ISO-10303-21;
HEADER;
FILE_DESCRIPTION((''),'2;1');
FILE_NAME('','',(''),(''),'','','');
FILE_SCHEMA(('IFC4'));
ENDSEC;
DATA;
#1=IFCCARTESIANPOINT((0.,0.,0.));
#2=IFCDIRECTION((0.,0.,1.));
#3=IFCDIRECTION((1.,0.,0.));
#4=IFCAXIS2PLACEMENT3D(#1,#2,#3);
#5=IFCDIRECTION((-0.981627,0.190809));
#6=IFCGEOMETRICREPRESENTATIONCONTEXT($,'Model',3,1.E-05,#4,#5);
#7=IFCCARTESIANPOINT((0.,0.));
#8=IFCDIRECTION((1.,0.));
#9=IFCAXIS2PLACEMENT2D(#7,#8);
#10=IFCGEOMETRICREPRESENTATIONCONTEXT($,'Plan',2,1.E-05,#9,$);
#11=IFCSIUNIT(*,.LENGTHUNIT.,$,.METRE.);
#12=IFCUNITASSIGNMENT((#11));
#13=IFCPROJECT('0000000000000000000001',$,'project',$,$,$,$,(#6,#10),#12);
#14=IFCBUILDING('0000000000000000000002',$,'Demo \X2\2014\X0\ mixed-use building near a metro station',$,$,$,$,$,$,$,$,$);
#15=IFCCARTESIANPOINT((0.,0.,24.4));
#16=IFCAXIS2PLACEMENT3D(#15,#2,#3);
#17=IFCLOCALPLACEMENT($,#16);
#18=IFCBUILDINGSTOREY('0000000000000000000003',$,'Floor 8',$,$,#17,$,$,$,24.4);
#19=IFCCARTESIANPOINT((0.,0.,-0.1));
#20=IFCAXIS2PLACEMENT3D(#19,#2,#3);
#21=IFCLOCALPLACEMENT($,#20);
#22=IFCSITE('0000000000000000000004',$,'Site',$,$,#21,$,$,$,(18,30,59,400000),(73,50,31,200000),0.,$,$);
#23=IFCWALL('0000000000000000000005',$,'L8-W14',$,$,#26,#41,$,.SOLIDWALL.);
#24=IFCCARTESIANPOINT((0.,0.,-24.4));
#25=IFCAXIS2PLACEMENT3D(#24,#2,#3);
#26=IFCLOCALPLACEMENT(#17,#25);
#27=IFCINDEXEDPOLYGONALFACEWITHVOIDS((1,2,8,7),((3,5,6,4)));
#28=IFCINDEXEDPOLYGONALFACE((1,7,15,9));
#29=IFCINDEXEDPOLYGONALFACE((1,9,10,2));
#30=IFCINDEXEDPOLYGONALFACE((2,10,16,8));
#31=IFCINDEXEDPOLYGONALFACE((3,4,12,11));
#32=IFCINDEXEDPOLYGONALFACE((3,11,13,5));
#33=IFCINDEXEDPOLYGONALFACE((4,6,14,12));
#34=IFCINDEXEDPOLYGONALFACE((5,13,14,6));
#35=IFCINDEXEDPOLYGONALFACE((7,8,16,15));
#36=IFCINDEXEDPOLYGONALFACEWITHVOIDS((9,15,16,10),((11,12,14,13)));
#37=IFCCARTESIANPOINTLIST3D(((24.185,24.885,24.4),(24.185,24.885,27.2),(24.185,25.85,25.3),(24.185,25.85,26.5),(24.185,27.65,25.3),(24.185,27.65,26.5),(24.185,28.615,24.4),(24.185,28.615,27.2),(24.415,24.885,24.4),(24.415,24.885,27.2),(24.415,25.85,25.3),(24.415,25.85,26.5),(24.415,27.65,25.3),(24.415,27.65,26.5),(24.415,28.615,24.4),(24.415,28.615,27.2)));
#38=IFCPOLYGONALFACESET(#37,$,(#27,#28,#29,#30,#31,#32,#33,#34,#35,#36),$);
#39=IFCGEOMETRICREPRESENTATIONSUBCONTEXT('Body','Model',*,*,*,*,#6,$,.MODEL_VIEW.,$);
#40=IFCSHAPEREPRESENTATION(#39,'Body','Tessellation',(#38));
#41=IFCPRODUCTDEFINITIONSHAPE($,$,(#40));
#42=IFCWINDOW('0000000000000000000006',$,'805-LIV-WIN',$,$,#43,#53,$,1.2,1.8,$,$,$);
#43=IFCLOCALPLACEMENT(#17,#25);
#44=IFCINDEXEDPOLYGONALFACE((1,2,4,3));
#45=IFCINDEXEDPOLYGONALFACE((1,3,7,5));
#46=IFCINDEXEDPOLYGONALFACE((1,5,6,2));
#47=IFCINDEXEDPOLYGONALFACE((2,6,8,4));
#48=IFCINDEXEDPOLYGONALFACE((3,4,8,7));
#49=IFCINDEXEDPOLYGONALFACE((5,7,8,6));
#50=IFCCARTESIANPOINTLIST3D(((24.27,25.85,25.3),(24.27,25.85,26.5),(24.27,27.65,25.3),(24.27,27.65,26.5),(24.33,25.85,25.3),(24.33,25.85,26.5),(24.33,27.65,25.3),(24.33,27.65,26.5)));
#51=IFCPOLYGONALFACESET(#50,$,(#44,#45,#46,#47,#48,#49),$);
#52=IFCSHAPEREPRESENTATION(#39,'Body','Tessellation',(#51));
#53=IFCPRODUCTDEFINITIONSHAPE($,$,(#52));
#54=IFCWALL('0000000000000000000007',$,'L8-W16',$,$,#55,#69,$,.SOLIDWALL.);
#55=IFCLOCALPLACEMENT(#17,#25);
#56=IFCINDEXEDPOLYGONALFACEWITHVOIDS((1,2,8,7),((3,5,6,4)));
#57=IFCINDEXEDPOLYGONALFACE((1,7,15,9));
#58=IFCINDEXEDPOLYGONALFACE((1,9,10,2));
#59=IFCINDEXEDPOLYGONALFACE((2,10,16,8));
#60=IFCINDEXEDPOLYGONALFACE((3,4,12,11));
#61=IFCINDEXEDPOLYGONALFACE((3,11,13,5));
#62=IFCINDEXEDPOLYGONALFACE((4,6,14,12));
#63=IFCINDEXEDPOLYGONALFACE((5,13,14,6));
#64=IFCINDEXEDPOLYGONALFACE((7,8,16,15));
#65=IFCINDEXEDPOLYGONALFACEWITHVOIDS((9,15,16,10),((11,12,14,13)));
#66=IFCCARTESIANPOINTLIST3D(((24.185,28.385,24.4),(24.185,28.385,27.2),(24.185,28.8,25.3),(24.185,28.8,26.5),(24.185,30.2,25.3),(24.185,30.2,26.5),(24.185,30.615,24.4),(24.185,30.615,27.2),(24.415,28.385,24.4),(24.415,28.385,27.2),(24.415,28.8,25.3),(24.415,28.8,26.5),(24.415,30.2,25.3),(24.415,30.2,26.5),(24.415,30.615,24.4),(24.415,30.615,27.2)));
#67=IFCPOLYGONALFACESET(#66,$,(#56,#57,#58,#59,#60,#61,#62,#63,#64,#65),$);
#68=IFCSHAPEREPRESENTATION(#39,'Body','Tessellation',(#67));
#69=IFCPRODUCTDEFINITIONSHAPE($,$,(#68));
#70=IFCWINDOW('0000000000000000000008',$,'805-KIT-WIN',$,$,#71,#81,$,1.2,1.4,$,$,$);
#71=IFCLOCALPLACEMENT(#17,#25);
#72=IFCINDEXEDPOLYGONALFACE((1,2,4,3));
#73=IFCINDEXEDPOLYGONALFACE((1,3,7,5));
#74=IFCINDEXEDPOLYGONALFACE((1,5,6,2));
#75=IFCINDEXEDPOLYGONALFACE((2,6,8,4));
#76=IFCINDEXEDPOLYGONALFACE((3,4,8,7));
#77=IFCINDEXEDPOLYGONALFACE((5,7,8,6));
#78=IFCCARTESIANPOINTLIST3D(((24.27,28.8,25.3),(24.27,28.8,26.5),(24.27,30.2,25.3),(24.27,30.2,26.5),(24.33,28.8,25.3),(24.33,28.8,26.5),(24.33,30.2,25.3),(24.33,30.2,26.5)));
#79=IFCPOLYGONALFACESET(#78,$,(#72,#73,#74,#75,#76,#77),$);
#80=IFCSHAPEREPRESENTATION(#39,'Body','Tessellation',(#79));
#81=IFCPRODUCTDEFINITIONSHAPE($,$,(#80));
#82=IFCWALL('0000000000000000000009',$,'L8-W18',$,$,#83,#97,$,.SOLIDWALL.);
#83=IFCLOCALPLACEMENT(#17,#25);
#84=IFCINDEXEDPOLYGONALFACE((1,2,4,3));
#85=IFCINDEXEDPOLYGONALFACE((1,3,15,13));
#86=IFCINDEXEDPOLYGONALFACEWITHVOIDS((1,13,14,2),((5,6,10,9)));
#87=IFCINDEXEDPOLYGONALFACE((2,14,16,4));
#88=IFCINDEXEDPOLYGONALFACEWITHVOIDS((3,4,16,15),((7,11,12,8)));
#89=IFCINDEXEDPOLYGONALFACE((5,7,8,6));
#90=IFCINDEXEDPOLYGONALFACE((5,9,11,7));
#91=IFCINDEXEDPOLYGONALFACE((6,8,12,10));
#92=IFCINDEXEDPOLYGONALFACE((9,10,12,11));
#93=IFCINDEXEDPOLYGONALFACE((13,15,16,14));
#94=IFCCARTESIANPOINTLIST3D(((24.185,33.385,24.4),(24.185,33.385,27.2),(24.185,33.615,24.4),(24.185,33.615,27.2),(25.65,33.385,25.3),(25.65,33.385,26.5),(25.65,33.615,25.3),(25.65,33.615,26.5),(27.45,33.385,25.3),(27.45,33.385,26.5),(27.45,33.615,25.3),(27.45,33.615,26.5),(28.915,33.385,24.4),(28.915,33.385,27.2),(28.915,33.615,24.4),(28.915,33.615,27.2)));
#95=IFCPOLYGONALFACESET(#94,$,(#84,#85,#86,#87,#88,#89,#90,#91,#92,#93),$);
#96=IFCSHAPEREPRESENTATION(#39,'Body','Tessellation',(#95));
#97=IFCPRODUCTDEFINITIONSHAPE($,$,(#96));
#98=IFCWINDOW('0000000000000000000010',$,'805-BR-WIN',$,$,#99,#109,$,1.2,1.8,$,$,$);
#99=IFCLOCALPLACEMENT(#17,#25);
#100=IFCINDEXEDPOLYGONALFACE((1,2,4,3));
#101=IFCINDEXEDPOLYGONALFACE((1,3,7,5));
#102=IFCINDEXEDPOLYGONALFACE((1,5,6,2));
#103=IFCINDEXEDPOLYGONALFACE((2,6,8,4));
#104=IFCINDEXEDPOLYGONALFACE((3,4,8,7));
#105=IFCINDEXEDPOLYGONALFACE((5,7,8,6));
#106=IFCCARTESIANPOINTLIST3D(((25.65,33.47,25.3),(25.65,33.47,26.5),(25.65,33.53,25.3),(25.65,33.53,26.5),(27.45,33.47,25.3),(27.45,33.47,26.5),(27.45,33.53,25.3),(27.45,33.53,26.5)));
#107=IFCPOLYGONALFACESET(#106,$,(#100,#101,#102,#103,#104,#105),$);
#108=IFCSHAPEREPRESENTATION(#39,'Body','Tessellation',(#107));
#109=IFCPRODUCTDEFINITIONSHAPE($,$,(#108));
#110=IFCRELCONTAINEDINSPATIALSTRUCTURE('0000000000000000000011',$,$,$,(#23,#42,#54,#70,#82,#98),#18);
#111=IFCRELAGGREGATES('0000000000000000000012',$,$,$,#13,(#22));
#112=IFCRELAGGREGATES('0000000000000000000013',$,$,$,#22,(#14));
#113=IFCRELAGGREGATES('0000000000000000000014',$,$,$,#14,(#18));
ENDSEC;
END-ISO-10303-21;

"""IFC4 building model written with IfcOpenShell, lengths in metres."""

from ifc_helpers import new_model, si_unit, direction, frame, origin_with_axes, origin_2d_with_axis, place, context, subcontext, project, spatial, line, indexed_curve, outline, extrude, element, fill, save


model = new_model("IFC4")

# Units and contexts
model_context = context("Model", 3, precision=1e-05, world=origin_with_axes(), true_north=direction((-0.981627, 0.190809)))
plan_context = context("Plan", 2, precision=1e-05, world=origin_2d_with_axis())
body_context = subcontext(model_context, "Body", "Model", "MODEL_VIEW")
ifc_project = project(units=[si_unit("LENGTHUNIT", "METRE")], contexts=[model_context, plan_context])

# Site, building, storey
site_placement = place(None, frame((0.0, 0.0, -0.1), z_axis=(0.0, 0.0, 1.0), x_axis=(1.0, 0.0, 0.0)))
site = spatial("IfcSite", under=ifc_project, at=site_placement, Name="Site", RefLatitude=(18, 30, 59, 400000), RefLongitude=(73, 50, 31, 200000), RefElevation=0.0)
building = spatial("IfcBuilding", under=site, Name="Demo — mixed-use building near a metro station")
storey_placement = place(None, frame((0.0, 0.0, 24.4), z_axis=(0.0, 0.0, 1.0), x_axis=(1.0, 0.0, 0.0)))
storey = spatial("IfcBuildingStorey", under=building, at=storey_placement, Name="Floor 8", Elevation=24.4)

# Wall, opening, window
wall_1_placement = place(storey_placement, frame((0.0, 0.0, -24.4), z_axis=(0.0, 0.0, 1.0), x_axis=(1.0, 0.0, 0.0)))
wall_1 = element("IfcWall", 1, at=wall_1_placement, inside=storey, Name="L8-W14", PredefinedType="SOLIDWALL", context=body_context, shape_type="SweptSolid", body=[
    extrude(outline(indexed_curve([(24.415, 28.615), (24.415, 24.885), (24.185, 24.885), (24.185, 28.615)], segments=[line(1, 2, 3, 4, 1)])), frame((0.0, 0.0, 24.4), z_axis=(0.0, 0.0, 1.0), x_axis=(1.0, 0.0, 0.0)), (0.0, 0.0, 1.0), 2.8),
])
opening_1_placement = place(wall_1_placement, origin_with_axes())
opening_1 = element("IfcOpeningElement", 2, at=opening_1_placement, cuts=wall_1, context=body_context, shape_type="SweptSolid", body=[
    extrude(outline(indexed_curve([(24.465, 27.65), (24.465, 25.85), (24.135, 25.85), (24.135, 27.65)], segments=[line(1, 2, 3, 4, 1)])), frame((0.0, 0.0, 25.3), z_axis=(0.0, 0.0, 1.0), x_axis=(1.0, 0.0, 0.0)), (0.0, 0.0, 1.0), 1.2),
])
window_1_placement = place(storey_placement, frame((0.0, 0.0, -24.4), z_axis=(0.0, 0.0, 1.0), x_axis=(1.0, 0.0, 0.0)))
window_1 = element("IfcWindow", 3, at=window_1_placement, inside=storey, Name="805-LIV-WIN", OverallHeight=1.2, OverallWidth=1.8, context=body_context, shape_type="SweptSolid", body=[
    extrude(outline(indexed_curve([(24.33, 27.65), (24.33, 25.85), (24.27, 25.85), (24.27, 27.65)], segments=[line(1, 2, 3, 4, 1)])), frame((0.0, 0.0, 25.3), z_axis=(0.0, 0.0, 1.0), x_axis=(1.0, 0.0, 0.0)), (0.0, 0.0, 1.0), 1.2),
])
fill(opening_1, window_1)

# Wall, opening, window
wall_2_placement = place(storey_placement, frame((0.0, 0.0, -24.4), z_axis=(0.0, 0.0, 1.0), x_axis=(1.0, 0.0, 0.0)))
wall_2 = element("IfcWall", 4, at=wall_2_placement, inside=storey, Name="L8-W16", PredefinedType="SOLIDWALL", context=body_context, shape_type="SweptSolid", body=[
    extrude(outline(indexed_curve([(24.415, 30.615), (24.415, 28.385), (24.185, 28.385), (24.185, 30.615)], segments=[line(1, 2, 3, 4, 1)])), frame((0.0, 0.0, 24.4), z_axis=(0.0, 0.0, 1.0), x_axis=(1.0, 0.0, 0.0)), (0.0, 0.0, 1.0), 2.8),
])
opening_2_placement = place(wall_2_placement, origin_with_axes())
opening_2 = element("IfcOpeningElement", 5, at=opening_2_placement, cuts=wall_2, context=body_context, shape_type="SweptSolid", body=[
    extrude(outline(indexed_curve([(24.465, 30.2), (24.465, 28.8), (24.135, 28.8), (24.135, 30.2)], segments=[line(1, 2, 3, 4, 1)])), frame((0.0, 0.0, 25.3), z_axis=(0.0, 0.0, 1.0), x_axis=(1.0, 0.0, 0.0)), (0.0, 0.0, 1.0), 1.2),
])
window_2_placement = place(storey_placement, frame((0.0, 0.0, -24.4), z_axis=(0.0, 0.0, 1.0), x_axis=(1.0, 0.0, 0.0)))
window_2 = element("IfcWindow", 6, at=window_2_placement, inside=storey, Name="805-KIT-WIN", OverallHeight=1.2, OverallWidth=1.4, context=body_context, shape_type="SweptSolid", body=[
    extrude(outline(indexed_curve([(24.33, 30.2), (24.33, 28.8), (24.27, 28.8), (24.27, 30.2)], segments=[line(1, 2, 3, 4, 1)])), frame((0.0, 0.0, 25.3), z_axis=(0.0, 0.0, 1.0), x_axis=(1.0, 0.0, 0.0)), (0.0, 0.0, 1.0), 1.2),
])
fill(opening_2, window_2)

# Wall, opening, window
wall_3_placement = place(storey_placement, frame((0.0, 0.0, -24.4), z_axis=(0.0, 0.0, 1.0), x_axis=(1.0, 0.0, 0.0)))
wall_3 = element("IfcWall", 7, at=wall_3_placement, inside=storey, Name="L8-W18", PredefinedType="SOLIDWALL", context=body_context, shape_type="SweptSolid", body=[
    extrude(outline(indexed_curve([(28.915, 33.385), (24.185, 33.385), (24.185, 33.615), (28.915, 33.615)], segments=[line(1, 2, 3, 4, 1)])), frame((0.0, 0.0, 24.4), z_axis=(0.0, 0.0, 1.0), x_axis=(1.0, 0.0, 0.0)), (0.0, 0.0, 1.0), 2.8),
])
opening_3_placement = place(wall_3_placement, origin_with_axes())
opening_3 = element("IfcOpeningElement", 8, at=opening_3_placement, cuts=wall_3, context=body_context, shape_type="SweptSolid", body=[
    extrude(outline(indexed_curve([(27.45, 33.335), (25.65, 33.335), (25.65, 33.665), (27.45, 33.665)], segments=[line(1, 2, 3, 4, 1)])), frame((0.0, 0.0, 25.3), z_axis=(0.0, 0.0, 1.0), x_axis=(1.0, 0.0, 0.0)), (0.0, 0.0, 1.0), 1.2),
])
window_3_placement = place(storey_placement, frame((0.0, 0.0, -24.4), z_axis=(0.0, 0.0, 1.0), x_axis=(1.0, 0.0, 0.0)))
window_3 = element("IfcWindow", 9, at=window_3_placement, inside=storey, Name="805-BR-WIN", OverallHeight=1.2, OverallWidth=1.8, context=body_context, shape_type="SweptSolid", body=[
    extrude(outline(indexed_curve([(27.45, 33.47), (25.65, 33.47), (25.65, 33.53), (27.45, 33.53)], segments=[line(1, 2, 3, 4, 1)])), frame((0.0, 0.0, 25.3), z_axis=(0.0, 0.0, 1.0), x_axis=(1.0, 0.0, 0.0)), (0.0, 0.0, 1.0), 1.2),
])
fill(opening_3, window_3)

save(model, "model.ifc")
